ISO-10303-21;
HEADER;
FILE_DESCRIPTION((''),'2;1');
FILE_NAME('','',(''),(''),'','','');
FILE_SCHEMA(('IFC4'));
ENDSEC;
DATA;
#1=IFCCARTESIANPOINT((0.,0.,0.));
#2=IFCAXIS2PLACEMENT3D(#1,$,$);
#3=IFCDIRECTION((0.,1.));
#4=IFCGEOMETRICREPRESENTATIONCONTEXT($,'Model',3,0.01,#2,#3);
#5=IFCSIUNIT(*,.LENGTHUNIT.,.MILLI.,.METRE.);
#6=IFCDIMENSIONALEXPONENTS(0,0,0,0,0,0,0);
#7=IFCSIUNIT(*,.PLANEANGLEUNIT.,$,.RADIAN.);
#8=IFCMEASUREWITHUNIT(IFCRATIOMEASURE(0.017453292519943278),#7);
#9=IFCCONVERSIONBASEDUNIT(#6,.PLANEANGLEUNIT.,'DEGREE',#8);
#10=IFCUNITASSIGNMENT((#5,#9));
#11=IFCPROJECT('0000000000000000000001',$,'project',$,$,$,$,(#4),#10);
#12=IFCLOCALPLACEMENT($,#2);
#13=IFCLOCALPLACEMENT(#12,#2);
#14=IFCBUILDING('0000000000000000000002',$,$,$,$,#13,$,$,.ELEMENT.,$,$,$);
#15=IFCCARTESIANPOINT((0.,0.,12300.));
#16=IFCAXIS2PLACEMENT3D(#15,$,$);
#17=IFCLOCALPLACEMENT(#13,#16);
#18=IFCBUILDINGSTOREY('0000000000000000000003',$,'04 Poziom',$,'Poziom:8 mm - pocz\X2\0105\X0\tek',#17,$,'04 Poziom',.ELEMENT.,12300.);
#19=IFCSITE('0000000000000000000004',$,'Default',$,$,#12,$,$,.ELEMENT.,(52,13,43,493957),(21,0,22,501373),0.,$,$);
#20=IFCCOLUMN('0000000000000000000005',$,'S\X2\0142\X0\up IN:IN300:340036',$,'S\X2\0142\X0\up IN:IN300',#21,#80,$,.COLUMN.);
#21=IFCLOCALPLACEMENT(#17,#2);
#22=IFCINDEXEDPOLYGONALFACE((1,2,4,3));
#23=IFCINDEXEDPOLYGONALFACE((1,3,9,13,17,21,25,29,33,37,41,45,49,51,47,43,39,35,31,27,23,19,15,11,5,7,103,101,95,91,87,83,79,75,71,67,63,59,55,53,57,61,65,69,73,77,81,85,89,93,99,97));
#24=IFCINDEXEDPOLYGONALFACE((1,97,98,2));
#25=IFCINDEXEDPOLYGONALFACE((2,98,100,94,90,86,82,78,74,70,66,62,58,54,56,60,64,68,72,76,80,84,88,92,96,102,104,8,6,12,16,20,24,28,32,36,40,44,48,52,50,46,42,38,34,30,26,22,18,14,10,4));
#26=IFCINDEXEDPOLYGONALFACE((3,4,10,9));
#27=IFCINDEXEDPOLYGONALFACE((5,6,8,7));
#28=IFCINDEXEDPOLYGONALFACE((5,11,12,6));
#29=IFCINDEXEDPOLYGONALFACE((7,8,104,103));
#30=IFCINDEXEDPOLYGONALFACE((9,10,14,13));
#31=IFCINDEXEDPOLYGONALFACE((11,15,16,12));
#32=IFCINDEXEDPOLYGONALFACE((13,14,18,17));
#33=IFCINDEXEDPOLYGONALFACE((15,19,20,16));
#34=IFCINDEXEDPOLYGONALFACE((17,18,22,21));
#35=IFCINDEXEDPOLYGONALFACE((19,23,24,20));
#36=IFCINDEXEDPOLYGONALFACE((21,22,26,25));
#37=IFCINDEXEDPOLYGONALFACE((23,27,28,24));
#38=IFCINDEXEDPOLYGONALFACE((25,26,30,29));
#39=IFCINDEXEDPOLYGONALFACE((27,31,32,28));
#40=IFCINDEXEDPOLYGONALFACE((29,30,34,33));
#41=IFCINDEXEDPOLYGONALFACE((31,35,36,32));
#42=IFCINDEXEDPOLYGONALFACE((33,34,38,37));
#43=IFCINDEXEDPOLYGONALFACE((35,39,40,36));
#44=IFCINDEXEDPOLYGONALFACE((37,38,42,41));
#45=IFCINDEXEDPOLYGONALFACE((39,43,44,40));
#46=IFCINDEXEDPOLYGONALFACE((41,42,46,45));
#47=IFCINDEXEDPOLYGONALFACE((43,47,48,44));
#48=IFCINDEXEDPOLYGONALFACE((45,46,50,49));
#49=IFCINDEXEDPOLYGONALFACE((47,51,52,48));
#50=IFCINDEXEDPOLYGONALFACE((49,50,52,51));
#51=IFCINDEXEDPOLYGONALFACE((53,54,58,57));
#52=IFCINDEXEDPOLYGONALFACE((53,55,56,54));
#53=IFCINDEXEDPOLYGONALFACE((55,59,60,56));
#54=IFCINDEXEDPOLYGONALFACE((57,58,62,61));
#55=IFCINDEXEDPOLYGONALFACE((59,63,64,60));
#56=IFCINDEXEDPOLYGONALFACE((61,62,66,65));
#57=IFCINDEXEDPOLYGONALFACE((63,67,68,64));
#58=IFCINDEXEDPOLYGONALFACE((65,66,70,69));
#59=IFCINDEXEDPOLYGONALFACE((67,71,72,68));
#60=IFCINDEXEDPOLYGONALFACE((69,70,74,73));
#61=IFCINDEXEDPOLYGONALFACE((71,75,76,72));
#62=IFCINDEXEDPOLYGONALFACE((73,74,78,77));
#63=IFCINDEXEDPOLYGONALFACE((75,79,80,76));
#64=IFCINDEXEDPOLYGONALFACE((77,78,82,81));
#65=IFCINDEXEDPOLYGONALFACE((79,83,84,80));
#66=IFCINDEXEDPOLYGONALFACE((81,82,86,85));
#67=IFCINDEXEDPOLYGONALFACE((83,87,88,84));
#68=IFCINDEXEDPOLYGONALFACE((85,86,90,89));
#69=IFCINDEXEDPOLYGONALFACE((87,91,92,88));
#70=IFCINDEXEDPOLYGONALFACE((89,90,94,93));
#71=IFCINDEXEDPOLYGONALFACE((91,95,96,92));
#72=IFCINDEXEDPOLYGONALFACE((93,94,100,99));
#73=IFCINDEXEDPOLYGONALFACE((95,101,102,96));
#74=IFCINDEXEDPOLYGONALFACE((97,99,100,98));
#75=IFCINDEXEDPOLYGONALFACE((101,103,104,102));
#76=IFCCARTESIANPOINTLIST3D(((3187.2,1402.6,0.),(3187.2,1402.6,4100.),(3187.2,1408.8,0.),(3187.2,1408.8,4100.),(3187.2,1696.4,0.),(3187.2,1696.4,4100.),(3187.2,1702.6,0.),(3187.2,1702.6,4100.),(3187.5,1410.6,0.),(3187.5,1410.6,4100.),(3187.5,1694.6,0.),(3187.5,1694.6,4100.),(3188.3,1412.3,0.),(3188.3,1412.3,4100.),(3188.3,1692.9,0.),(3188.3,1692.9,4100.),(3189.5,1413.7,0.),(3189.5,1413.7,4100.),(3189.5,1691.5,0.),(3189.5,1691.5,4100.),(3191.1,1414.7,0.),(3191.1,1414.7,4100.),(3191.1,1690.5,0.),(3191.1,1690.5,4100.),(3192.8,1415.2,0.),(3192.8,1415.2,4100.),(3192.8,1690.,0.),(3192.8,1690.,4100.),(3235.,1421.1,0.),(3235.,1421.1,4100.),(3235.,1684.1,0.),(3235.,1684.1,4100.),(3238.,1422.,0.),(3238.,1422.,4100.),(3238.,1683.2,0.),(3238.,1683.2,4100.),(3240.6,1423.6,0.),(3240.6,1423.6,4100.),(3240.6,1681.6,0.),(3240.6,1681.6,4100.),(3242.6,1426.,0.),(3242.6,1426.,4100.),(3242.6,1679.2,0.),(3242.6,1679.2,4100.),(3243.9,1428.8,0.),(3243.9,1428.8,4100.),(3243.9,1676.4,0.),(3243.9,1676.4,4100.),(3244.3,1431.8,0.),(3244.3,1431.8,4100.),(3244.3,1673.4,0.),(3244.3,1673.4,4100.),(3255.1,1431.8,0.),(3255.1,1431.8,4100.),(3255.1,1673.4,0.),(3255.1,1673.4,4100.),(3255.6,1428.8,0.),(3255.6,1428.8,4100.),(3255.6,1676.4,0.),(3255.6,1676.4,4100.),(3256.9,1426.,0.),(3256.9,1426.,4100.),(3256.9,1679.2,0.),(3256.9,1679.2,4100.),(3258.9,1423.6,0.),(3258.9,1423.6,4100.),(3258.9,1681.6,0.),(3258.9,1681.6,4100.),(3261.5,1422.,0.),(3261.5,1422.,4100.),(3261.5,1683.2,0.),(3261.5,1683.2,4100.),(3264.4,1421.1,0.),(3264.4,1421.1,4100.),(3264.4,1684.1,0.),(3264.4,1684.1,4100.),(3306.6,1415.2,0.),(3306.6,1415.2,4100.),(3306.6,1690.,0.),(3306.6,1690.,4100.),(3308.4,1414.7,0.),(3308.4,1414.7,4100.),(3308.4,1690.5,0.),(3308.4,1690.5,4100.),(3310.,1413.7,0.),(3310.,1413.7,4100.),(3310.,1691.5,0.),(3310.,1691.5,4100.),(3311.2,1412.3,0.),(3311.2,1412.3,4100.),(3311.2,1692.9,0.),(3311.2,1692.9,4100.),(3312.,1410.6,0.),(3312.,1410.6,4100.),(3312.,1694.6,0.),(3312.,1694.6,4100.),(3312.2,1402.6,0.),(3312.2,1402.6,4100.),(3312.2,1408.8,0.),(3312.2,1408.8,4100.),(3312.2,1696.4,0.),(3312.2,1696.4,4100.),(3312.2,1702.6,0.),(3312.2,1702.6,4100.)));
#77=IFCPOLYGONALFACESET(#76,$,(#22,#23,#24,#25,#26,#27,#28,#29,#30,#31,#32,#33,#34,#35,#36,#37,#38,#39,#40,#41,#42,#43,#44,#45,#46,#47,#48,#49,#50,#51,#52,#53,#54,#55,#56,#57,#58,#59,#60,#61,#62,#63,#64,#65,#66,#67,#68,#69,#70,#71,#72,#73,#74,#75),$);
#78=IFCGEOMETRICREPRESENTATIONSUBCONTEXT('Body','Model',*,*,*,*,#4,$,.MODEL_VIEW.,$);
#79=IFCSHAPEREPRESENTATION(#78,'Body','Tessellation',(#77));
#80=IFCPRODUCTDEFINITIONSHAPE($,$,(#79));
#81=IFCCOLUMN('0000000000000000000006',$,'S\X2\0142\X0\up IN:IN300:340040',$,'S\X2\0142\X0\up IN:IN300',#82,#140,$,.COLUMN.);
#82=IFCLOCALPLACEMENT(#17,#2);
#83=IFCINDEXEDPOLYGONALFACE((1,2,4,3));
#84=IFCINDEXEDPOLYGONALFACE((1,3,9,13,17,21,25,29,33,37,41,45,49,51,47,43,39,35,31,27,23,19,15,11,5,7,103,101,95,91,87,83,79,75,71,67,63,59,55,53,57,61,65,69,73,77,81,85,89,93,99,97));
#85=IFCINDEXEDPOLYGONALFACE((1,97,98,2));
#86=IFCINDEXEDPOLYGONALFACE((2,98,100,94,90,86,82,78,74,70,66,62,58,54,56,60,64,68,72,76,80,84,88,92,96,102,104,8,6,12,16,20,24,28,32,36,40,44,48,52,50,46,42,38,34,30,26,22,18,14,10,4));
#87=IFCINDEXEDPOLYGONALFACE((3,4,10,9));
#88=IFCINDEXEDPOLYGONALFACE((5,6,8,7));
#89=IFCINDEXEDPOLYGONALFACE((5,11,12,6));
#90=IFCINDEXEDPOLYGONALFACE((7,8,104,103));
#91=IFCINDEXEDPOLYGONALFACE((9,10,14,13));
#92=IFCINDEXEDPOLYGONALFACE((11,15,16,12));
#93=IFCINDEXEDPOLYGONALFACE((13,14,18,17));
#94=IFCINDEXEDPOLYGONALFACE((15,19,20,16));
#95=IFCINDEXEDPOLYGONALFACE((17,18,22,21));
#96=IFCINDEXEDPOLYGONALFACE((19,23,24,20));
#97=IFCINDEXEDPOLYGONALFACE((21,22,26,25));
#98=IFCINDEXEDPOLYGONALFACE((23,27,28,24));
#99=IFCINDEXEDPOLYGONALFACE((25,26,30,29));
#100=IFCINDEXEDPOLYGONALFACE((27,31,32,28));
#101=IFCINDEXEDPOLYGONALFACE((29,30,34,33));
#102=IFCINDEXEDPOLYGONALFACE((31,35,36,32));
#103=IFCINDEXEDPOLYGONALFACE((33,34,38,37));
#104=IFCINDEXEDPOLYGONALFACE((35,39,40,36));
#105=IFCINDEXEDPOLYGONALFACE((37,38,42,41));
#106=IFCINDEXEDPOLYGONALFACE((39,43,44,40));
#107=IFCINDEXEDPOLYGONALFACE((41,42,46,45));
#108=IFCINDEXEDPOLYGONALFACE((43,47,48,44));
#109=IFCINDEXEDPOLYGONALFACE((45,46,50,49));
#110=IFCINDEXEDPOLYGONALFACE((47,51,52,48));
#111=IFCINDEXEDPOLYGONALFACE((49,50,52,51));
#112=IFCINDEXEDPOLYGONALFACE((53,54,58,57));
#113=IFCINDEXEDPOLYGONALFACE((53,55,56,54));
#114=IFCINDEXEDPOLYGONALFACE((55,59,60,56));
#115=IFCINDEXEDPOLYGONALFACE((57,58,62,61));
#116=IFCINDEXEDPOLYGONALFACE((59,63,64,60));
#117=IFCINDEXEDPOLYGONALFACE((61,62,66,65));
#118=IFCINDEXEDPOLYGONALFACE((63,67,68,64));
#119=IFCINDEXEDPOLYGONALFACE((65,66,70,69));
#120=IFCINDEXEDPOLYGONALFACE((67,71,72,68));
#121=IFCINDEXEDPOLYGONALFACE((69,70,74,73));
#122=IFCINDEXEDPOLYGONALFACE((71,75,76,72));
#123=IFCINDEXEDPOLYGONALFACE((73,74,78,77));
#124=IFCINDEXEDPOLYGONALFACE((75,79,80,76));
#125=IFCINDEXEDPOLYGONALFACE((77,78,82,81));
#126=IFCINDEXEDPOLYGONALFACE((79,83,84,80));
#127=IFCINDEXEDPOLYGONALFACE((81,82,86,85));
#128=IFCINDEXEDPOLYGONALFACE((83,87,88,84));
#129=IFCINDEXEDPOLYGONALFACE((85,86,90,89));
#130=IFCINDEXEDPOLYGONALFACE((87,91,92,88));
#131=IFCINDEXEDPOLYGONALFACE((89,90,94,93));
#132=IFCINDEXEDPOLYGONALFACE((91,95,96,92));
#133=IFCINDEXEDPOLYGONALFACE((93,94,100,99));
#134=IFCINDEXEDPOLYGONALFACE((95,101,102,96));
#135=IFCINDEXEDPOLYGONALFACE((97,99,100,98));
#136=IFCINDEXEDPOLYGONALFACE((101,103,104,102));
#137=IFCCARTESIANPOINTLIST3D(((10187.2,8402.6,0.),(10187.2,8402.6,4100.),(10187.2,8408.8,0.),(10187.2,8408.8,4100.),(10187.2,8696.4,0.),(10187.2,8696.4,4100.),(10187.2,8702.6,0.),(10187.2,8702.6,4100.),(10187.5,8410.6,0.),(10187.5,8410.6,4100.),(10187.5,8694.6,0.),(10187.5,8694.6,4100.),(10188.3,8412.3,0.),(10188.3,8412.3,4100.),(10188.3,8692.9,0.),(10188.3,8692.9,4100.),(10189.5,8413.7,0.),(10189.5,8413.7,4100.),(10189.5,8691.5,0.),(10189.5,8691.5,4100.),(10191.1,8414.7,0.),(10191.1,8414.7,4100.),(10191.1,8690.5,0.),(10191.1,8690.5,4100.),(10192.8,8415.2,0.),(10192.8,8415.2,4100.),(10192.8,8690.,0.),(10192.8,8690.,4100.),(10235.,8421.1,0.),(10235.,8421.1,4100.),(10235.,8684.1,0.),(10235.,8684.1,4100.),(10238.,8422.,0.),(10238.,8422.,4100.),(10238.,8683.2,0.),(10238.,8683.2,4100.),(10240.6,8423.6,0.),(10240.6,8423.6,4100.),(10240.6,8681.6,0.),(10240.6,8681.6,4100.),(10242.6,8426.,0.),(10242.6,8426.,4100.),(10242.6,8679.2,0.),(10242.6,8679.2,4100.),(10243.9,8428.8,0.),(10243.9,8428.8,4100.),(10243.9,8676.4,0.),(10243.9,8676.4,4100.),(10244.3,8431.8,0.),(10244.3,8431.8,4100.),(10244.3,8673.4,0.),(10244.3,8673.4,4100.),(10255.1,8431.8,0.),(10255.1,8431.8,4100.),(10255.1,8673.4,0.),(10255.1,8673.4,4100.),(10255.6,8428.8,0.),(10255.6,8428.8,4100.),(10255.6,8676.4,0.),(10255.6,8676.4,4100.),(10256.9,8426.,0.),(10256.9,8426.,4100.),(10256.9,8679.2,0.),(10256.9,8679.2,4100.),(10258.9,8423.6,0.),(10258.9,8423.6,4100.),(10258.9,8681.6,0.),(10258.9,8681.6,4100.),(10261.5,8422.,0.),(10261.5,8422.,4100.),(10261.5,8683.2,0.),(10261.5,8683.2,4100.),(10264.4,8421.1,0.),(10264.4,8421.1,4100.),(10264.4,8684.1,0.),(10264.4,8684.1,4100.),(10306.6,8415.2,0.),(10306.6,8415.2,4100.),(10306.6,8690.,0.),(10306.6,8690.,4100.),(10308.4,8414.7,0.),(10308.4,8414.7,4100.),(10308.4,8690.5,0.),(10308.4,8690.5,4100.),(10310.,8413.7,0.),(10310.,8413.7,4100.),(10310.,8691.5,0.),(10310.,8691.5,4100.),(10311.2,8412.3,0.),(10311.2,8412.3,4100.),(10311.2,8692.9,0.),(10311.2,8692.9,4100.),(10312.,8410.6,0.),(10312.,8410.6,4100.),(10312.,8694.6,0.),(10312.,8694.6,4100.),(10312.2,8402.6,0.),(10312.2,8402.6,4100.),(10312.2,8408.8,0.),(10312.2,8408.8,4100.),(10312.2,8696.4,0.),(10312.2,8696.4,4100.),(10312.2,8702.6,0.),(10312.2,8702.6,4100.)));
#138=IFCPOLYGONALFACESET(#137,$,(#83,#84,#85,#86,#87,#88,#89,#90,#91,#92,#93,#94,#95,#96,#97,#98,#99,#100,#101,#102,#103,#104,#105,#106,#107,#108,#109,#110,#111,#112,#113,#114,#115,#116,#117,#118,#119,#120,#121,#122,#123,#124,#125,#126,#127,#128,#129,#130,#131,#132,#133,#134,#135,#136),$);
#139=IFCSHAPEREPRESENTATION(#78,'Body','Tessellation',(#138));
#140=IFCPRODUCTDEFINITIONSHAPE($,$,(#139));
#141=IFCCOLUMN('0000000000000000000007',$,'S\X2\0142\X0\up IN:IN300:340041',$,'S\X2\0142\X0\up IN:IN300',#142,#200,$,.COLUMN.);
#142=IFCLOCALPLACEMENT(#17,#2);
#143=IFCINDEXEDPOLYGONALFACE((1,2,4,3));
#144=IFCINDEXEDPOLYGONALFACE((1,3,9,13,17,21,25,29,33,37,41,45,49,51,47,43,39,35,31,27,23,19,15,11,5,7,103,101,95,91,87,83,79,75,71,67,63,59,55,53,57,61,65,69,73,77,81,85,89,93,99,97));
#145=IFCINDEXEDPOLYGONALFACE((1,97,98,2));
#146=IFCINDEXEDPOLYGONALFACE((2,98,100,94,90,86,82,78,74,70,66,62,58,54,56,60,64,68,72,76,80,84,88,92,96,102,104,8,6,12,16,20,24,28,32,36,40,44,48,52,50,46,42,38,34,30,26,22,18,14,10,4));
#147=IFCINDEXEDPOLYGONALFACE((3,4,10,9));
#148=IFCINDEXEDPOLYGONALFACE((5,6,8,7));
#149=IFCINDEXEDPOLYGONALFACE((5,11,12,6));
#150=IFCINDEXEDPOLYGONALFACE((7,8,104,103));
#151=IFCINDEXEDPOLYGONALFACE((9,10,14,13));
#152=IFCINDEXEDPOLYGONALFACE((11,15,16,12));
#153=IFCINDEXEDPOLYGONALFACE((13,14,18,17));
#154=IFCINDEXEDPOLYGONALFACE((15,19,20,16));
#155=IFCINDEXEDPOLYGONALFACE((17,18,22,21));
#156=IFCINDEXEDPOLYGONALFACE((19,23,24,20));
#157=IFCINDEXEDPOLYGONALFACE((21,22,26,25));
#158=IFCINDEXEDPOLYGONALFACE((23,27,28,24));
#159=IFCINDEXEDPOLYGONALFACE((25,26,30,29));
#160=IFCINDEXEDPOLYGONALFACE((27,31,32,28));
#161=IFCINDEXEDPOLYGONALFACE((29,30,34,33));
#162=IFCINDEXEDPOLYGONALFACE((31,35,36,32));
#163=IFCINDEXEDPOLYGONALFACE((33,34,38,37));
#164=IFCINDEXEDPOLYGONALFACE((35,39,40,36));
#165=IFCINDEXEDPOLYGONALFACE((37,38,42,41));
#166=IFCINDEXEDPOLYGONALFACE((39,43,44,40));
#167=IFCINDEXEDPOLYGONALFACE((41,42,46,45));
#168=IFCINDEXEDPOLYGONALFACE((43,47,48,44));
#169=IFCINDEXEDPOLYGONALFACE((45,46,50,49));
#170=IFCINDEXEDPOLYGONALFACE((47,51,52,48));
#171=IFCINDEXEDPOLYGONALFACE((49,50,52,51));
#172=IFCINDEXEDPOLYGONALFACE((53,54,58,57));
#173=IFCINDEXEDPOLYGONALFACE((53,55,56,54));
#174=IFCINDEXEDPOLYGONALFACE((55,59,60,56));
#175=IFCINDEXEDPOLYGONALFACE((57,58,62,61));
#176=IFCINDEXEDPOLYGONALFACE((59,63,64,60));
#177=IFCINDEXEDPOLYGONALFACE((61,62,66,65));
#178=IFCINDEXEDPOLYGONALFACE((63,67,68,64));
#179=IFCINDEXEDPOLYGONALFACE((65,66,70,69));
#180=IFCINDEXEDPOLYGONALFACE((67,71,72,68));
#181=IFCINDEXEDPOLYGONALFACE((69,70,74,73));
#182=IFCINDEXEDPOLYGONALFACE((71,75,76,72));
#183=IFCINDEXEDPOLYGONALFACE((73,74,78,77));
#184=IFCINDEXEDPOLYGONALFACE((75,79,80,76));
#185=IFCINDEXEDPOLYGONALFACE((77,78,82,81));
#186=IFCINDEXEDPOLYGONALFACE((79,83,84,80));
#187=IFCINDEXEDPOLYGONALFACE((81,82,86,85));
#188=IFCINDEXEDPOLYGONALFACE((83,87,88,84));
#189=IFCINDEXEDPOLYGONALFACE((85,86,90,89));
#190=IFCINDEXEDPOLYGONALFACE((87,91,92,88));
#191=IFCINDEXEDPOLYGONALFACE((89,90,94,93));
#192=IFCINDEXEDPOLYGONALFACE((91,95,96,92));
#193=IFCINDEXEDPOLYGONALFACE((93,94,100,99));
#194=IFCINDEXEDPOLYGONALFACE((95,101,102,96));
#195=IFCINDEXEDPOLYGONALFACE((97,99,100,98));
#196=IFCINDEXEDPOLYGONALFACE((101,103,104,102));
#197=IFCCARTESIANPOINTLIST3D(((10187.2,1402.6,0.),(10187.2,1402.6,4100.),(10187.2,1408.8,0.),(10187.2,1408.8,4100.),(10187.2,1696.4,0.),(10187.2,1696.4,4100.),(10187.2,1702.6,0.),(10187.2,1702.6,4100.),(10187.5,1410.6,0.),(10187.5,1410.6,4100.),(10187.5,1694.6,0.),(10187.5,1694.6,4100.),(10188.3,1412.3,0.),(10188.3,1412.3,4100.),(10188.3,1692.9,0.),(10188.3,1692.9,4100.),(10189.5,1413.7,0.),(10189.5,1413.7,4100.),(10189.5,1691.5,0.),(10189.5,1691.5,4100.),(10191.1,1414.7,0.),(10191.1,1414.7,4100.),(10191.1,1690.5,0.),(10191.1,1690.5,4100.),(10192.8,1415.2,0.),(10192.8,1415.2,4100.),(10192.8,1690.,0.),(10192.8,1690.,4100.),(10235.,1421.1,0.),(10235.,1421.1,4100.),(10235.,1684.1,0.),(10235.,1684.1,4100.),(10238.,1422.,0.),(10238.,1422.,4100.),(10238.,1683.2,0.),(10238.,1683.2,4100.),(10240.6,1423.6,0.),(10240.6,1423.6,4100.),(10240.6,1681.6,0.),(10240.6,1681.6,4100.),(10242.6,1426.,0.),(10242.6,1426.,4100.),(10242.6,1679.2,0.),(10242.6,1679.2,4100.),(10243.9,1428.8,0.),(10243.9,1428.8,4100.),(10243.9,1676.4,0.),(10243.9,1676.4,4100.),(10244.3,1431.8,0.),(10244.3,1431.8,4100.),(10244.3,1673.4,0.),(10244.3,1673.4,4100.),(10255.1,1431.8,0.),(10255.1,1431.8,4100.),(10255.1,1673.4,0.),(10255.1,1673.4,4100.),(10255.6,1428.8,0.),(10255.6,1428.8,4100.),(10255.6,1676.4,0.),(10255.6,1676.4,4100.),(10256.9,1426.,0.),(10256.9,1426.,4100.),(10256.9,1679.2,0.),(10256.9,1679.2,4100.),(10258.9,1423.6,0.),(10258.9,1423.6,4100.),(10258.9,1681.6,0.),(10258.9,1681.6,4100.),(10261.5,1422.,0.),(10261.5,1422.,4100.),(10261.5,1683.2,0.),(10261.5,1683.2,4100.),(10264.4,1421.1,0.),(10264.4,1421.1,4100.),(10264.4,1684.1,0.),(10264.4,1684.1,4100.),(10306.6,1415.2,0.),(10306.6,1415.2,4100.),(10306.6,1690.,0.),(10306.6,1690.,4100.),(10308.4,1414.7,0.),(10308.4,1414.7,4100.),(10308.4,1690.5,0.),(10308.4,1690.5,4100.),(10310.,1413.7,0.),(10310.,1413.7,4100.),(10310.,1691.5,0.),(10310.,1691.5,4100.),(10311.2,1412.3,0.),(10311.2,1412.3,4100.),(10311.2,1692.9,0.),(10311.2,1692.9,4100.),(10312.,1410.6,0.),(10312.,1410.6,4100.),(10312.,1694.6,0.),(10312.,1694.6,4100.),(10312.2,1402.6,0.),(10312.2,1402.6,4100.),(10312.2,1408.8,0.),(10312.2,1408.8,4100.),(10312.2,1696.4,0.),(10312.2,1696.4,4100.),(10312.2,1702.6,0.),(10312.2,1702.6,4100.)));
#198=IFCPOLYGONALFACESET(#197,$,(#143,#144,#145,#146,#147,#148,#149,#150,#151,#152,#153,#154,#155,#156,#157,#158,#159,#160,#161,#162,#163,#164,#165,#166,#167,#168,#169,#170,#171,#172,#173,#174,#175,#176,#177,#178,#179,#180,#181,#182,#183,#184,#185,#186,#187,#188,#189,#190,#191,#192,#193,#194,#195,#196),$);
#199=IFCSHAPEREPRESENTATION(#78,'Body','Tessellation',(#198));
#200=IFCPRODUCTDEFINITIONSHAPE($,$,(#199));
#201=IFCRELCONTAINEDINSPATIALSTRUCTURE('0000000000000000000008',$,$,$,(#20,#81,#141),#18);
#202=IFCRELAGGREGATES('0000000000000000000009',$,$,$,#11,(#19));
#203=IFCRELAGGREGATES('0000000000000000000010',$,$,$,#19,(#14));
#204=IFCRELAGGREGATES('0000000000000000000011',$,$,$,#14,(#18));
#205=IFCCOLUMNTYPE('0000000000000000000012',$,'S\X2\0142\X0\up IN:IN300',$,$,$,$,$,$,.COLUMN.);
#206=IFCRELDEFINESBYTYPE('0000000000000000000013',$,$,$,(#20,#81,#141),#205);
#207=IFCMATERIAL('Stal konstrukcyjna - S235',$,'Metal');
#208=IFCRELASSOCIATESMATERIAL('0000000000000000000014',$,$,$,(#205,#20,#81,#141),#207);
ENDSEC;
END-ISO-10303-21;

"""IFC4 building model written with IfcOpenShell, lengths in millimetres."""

from ifc_helpers import new_model, entity, si_unit, converted_unit, direction, frame, origin, place, context, subcontext, project, spatial, line, arc, indexed_curve, outline, extrude, source, transform, mapped, material, type_object, type_shapes, element, save


model = new_model("IFC4")

# Units and contexts
model_context = context("Model", 3, precision=0.01, world=origin(), true_north=direction((0.0, 1.0)))
body_context = subcontext(model_context, "Body", "Model", "MODEL_VIEW")
ifc_project = project(units=[si_unit("LENGTHUNIT", "METRE", prefix="MILLI"), converted_unit("PLANEANGLEUNIT", "DEGREE", entity("IfcRatioMeasure", 0.017453292519943278), si_unit("PLANEANGLEUNIT", "RADIAN"), dimensions=[0, 0, 0, 0, 0, 0, 0])], contexts=[model_context])

# Site, building, storey
site_placement = place(None, origin())
site = spatial("IfcSite", under=ifc_project, at=site_placement, Name="Default", CompositionType="ELEMENT", RefLatitude=(52, 13, 43, 493957), RefLongitude=(21, 0, 22, 501373), RefElevation=0.0)
building_placement = place(site_placement, origin())
building = spatial("IfcBuilding", under=site, at=building_placement, CompositionType="ELEMENT")
storey_placement = place(building_placement, frame((0.0, 0.0, 12300.0)))
storey = spatial("IfcBuildingStorey", under=building, at=storey_placement, Name="04 Poziom", ObjectType="Poziom:8 mm - początek", LongName="04 Poziom", CompositionType="ELEMENT", Elevation=12300.0)

# Columns
ifc_material_1 = material(Name="Stal konstrukcyjna - S235", Category="Metal")
column_type = type_object("IfcColumnType", Name="Słup IN:IN300", PredefinedType="COLUMN", material=ifc_material_1)
shared_shape_1 = source(origin(), body_context, "Body", "SweptSolid", [
    extrude(outline(indexed_curve([(143.8, -62.5), (150.0, -62.5), (150.0, 62.5), (143.8, 62.5), (139.6, 60.9), (137.4, 56.9), (131.5, 14.7), (127.9, 8.1), (120.8, 5.4), (-120.8, 5.4), (-127.9, 8.1), (-131.5, 14.7), (-137.4, 56.9), (-139.6, 60.9), (-143.8, 62.5), (-150.0, 62.5), (-150.0, -62.5), (-143.8, -62.5), (-139.6, -60.9), (-137.4, -56.9), (-131.5, -14.7), (-127.9, -8.1), (-120.8, -5.4), (120.8, -5.4), (127.9, -8.1), (131.5, -14.7), (137.4, -56.9), (139.6, -60.9)], segments=[line(1, 2, 3, 4), arc(4, 5, 6), line(6, 7), arc(7, 8, 9), line(9, 10), arc(10, 11, 12), line(12, 13), arc(13, 14, 15), line(15, 16, 17, 18), arc(18, 19, 20), line(20, 21), arc(21, 22, 23), line(23, 24), arc(24, 25, 26), line(26, 27), arc(27, 28, 1)], self_intersect=False)), frame((0.0, 0.0, 12300.0), z_axis=(0.0, 0.0, 1.0), x_axis=(0.0, -1.0, 0.0)), (0.0, 0.0, 1.0), 4100.0),
])
type_shapes(column_type, [shared_shape_1])
for number, where, name in (
    (1, (3249.7, 1552.6, -12300.0), "Słup IN:IN300:340036"),
    (2, (10249.7, 8552.6, -12300.0), "Słup IN:IN300:340040"),
    (3, (10249.7, 1552.6, -12300.0), "Słup IN:IN300:340041"),
):
    element("IfcColumn", number, at=place(storey_placement, frame(where)), inside=storey, type_object=column_type, material=ifc_material_1, Name=name, ObjectType="Słup IN:IN300", PredefinedType="COLUMN", context=body_context, shape_type="MappedRepresentation", body=[
        mapped(shared_shape_1, transform((0.0, 0.0, 0.0), scale=1.0)),
    ])

save(model, "model.ifc")
